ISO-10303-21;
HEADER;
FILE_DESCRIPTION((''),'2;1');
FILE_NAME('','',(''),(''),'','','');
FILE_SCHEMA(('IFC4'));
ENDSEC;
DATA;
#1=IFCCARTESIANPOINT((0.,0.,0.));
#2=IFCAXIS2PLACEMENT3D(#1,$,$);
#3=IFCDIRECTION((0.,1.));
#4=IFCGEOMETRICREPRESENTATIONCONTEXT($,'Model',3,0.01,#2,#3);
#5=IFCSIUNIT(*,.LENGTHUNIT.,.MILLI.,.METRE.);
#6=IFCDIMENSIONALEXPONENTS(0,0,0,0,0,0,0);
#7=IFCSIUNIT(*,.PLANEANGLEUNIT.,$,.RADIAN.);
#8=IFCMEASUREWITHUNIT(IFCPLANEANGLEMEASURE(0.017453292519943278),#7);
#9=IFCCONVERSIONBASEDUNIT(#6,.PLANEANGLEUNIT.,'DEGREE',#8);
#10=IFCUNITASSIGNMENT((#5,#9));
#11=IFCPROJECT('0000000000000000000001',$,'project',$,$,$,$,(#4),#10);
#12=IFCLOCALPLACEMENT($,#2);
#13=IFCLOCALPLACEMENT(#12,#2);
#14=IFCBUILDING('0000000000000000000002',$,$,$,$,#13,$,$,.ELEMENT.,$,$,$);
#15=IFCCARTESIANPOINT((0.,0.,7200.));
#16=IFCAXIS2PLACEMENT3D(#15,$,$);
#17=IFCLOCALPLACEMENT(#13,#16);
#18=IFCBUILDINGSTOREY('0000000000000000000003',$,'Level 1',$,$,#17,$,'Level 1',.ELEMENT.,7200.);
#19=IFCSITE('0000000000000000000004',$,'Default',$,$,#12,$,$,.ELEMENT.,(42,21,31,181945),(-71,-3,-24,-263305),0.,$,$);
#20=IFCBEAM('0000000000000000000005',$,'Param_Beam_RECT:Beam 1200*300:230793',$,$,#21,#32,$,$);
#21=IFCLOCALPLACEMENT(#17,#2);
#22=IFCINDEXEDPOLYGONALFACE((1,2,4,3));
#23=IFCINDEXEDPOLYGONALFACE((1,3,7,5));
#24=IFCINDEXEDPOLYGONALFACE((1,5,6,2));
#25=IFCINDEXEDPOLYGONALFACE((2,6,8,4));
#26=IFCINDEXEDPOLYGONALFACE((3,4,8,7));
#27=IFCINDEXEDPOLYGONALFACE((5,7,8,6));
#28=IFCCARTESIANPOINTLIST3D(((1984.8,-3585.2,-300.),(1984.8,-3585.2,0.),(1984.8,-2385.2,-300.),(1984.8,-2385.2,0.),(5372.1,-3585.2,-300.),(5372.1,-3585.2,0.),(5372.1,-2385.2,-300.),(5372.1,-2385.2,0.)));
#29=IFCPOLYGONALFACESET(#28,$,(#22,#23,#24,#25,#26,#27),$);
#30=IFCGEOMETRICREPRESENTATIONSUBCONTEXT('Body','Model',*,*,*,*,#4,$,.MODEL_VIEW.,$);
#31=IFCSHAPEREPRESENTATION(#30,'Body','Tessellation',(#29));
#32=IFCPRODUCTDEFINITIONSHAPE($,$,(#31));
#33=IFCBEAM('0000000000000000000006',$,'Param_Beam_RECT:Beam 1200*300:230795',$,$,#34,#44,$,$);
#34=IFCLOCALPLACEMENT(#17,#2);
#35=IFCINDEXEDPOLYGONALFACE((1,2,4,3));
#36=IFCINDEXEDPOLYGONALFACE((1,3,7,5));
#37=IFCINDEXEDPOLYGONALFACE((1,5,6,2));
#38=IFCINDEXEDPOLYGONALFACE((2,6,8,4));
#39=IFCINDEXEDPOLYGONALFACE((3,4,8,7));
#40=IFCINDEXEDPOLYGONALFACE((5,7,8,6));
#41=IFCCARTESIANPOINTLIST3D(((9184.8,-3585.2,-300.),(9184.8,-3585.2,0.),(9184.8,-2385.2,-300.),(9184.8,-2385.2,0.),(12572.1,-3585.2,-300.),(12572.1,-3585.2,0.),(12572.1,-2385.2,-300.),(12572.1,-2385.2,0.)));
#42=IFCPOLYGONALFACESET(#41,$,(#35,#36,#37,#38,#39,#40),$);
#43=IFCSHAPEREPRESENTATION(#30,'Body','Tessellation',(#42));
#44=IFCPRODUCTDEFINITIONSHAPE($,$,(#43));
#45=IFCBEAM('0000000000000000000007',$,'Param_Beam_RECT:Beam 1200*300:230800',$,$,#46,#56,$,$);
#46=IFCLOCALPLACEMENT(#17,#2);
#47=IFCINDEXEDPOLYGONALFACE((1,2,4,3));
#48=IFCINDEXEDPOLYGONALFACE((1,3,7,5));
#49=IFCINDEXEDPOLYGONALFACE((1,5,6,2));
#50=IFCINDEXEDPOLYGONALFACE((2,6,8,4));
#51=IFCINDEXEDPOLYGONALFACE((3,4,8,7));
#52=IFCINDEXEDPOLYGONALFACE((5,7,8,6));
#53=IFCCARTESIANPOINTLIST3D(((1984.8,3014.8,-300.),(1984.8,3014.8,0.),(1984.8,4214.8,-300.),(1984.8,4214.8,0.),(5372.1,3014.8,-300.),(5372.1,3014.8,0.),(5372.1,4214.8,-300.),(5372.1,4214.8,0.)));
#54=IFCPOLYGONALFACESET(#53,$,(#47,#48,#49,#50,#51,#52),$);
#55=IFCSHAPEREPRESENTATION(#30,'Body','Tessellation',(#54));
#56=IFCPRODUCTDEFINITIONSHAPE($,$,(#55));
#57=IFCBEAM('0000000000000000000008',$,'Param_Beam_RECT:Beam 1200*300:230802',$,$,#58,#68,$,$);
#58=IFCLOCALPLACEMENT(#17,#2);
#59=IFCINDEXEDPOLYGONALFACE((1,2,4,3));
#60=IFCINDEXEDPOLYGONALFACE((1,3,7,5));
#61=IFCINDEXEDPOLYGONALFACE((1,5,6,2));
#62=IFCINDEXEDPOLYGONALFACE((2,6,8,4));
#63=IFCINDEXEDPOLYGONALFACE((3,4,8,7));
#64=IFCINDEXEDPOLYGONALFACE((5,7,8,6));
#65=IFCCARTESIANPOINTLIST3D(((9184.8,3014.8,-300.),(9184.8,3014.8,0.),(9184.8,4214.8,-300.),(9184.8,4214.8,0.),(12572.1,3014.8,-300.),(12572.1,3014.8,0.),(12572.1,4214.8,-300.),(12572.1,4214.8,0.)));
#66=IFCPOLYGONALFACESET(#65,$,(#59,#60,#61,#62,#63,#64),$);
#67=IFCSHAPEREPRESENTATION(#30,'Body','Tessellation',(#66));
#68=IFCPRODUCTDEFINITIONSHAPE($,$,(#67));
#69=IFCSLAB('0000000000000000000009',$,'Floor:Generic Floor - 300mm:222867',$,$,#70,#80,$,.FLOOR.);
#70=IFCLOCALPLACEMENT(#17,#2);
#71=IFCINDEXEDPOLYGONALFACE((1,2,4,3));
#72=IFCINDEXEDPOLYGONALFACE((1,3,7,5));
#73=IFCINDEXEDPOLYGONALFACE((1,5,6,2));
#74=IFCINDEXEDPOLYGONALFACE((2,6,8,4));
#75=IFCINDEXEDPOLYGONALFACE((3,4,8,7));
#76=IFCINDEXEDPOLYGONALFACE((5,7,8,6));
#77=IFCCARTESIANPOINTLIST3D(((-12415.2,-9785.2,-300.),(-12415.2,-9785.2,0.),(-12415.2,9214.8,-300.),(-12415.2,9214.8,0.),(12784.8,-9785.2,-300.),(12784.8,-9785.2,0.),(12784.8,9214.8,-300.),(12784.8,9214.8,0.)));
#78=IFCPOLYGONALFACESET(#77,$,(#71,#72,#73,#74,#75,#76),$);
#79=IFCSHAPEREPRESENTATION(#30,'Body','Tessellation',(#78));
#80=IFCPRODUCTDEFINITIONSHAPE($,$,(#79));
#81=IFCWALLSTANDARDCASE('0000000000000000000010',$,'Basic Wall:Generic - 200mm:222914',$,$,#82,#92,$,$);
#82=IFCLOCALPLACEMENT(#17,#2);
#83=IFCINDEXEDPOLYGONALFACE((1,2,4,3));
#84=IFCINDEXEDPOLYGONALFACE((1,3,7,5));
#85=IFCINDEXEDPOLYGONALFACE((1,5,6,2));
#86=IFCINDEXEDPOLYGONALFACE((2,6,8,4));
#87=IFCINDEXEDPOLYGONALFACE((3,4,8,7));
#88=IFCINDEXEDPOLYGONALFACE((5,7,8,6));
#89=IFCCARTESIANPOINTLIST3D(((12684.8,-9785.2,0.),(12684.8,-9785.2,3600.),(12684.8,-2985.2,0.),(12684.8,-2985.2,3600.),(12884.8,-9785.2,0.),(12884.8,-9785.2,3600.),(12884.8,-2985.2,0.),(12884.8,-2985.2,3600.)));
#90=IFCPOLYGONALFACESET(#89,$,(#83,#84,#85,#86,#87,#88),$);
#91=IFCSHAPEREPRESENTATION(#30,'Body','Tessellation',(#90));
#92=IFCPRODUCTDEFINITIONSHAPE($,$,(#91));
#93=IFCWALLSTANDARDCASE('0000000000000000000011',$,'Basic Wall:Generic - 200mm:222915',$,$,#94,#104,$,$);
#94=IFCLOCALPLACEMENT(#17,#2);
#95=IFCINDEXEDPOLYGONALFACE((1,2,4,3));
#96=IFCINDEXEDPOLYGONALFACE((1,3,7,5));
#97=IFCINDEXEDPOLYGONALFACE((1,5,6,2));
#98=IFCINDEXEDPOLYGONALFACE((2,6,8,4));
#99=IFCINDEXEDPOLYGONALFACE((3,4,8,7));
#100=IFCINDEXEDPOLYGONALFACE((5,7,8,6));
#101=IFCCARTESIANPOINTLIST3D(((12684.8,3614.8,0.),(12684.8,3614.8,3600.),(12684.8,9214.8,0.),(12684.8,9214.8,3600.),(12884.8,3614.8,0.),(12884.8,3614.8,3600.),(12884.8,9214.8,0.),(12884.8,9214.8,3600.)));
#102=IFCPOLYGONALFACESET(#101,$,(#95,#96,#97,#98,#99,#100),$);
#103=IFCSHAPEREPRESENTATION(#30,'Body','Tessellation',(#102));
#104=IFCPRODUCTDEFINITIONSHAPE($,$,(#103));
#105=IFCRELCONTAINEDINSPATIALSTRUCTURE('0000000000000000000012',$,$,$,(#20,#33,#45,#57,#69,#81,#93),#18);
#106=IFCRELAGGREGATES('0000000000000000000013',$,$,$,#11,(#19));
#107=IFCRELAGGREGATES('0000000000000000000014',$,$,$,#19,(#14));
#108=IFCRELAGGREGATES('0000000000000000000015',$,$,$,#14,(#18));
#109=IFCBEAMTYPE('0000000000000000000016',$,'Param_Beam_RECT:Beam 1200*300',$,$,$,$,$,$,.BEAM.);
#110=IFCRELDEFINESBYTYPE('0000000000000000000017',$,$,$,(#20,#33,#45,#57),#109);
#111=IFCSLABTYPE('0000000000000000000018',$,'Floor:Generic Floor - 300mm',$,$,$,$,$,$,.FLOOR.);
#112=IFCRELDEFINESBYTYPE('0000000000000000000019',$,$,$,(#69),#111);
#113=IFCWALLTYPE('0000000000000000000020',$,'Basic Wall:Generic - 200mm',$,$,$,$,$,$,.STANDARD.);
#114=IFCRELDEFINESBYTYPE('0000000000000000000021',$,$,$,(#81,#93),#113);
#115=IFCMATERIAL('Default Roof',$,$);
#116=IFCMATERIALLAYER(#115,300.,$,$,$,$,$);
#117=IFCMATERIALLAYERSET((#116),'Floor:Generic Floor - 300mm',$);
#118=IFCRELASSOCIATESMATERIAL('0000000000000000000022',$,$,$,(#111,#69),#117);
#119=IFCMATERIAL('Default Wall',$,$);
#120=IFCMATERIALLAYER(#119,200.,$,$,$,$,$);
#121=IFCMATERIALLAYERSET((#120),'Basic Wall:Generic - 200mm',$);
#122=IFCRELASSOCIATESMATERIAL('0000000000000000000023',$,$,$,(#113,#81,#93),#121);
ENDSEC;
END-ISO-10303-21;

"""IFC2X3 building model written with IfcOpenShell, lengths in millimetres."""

from ifc_helpers import new_model, entity, si_unit, converted_unit, direction, frame, frame_2d, origin, origin_2d_with_axis, place, context, subcontext, project, spatial, rectangle, extrude, material, layer, layer_set, layer_usage, type_object, element, save


model = new_model("IFC2X3")

# Units and contexts
model_context = context("Model", 3, precision=0.01, world=origin(), true_north=direction((0.0, 1.0)))
body_context = subcontext(model_context, "Body", "Model", "MODEL_VIEW")
ifc_project = project(units=[si_unit("LENGTHUNIT", "METRE", prefix="MILLI"), converted_unit("PLANEANGLEUNIT", "DEGREE", entity("IfcPlaneAngleMeasure", 0.017453292519943278), si_unit("PLANEANGLEUNIT", "RADIAN"), dimensions=[0, 0, 0, 0, 0, 0, 0])], contexts=[model_context])

# Site, building, storey
site_placement = place(None, origin())
site = spatial("IfcSite", under=ifc_project, at=site_placement, Name="Default", CompositionType="ELEMENT", RefLatitude=(42, 21, 31, 181945), RefLongitude=(-71, -3, -24, -263305), RefElevation=0.0)
building_placement = place(site_placement, origin())
building = spatial("IfcBuilding", under=site, at=building_placement, CompositionType="ELEMENT")
storey_placement = place(building_placement, frame((0.0, 0.0, 7200.0)))
storey = spatial("IfcBuildingStorey", under=building, at=storey_placement, Name="Level 1", LongName="Level 1", CompositionType="ELEMENT", Elevation=7200.0)

# Beams
beam_type_1 = type_object("IfcBeamType", Name="Param_Beam_RECT:Beam 1200*300", PredefinedType="BEAM")
beam_1_placement = place(storey_placement, frame((1984.8, -2985.2, 0.0)))
element("IfcBeam", 1, at=beam_1_placement, inside=storey, type_object=beam_type_1, Name="Param_Beam_RECT:Beam 1200*300:230793", context=body_context, shape_type="SweptSolid", body=[
    extrude(rectangle(XDim=300.0, YDim=1200.0, at=frame_2d((0.0, 0.0), x_axis=(1.0, 0.0))), frame((0.0, 0.0, -150.0), z_axis=(1.0, 0.0, 0.0), x_axis=(0.0, 0.0, -1.0)), (0.0, 0.0, 1.0), 3387.3),
])
beam_2_placement = place(storey_placement, frame((9184.8, -2985.2, 0.0)))
element("IfcBeam", 2, at=beam_2_placement, inside=storey, type_object=beam_type_1, Name="Param_Beam_RECT:Beam 1200*300:230795", context=body_context, shape_type="SweptSolid", body=[
    extrude(rectangle(XDim=300.0, YDim=1200.0, at=frame_2d((0.0, 0.0), x_axis=(1.0, 0.0))), frame((0.0, 0.0, -150.0), z_axis=(1.0, 0.0, 0.0), x_axis=(0.0, 0.0, -1.0)), (0.0, 0.0, 1.0), 3387.3),
])
beam_3_placement = place(storey_placement, frame((1984.8, 3614.8, 0.0)))
element("IfcBeam", 3, at=beam_3_placement, inside=storey, type_object=beam_type_1, Name="Param_Beam_RECT:Beam 1200*300:230800", context=body_context, shape_type="SweptSolid", body=[
    extrude(rectangle(XDim=300.0, YDim=1200.0, at=frame_2d((0.0, 0.0), x_axis=(1.0, 0.0))), frame((0.0, 0.0, -150.0), z_axis=(1.0, 0.0, 0.0), x_axis=(0.0, 0.0, -1.0)), (0.0, 0.0, 1.0), 3387.3),
])
beam_4_placement = place(storey_placement, frame((9184.8, 3614.8, 0.0)))
element("IfcBeam", 4, at=beam_4_placement, inside=storey, type_object=beam_type_1, Name="Param_Beam_RECT:Beam 1200*300:230802", context=body_context, shape_type="SweptSolid", body=[
    extrude(rectangle(XDim=300.0, YDim=1200.0, at=frame_2d((0.0, 0.0), x_axis=(1.0, 0.0))), frame((0.0, 0.0, -150.0), z_axis=(1.0, 0.0, 0.0), x_axis=(0.0, 0.0, -1.0)), (0.0, 0.0, 1.0), 3387.3),
])

# Slab
ifc_material_1 = material(Name="Default Roof")
ifc_layer_1 = layer(ifc_material_1, 300.0)
ifc_layer_set_1 = layer_set([ifc_layer_1], Name="Floor:Generic Floor - 300mm")
ifc_layer_usage_1 = layer_usage(ifc_layer_set_1, "AXIS3", "POSITIVE", 0.0)
slab_type = type_object("IfcSlabType", Name="Floor:Generic Floor - 300mm", PredefinedType="FLOOR", material=ifc_layer_set_1)
slab_placement = place(storey_placement, origin())
element("IfcSlab", 5, at=slab_placement, inside=storey, type_object=slab_type, material=ifc_layer_usage_1, Name="Floor:Generic Floor - 300mm:222867", PredefinedType="FLOOR", context=body_context, shape_type="SweptSolid", body=[
    extrude(rectangle(XDim=19000.0, YDim=25200.0, at=origin_2d_with_axis()), frame((184.8, -285.2, 0.0), z_axis=(0.0, 0.0, -1.0), x_axis=(0.0, 1.0, 0.0)), (0.0, 0.0, 1.0), 300.0),
])

# Walls
ifc_material_2 = material(Name="Default Wall")
ifc_layer_2 = layer(ifc_material_2, 200.0)
ifc_layer_set_2 = layer_set([ifc_layer_2], Name="Basic Wall:Generic - 200mm")
ifc_layer_usage_2 = layer_usage(ifc_layer_set_2, "AXIS2", "NEGATIVE", 100.0)
wall_type = type_object("IfcWallType", Name="Basic Wall:Generic - 200mm", PredefinedType="STANDARD", material=ifc_layer_set_2)
wall_1_placement = place(storey_placement, frame((12784.8, -9785.2, 0.0), z_axis=(0.0, 0.0, 1.0), x_axis=(0.0, 1.0, 0.0)))
element("IfcWallStandardCase", 6, at=wall_1_placement, inside=storey, type_object=wall_type, material=ifc_layer_usage_2, Name="Basic Wall:Generic - 200mm:222914", context=body_context, shape_type="SweptSolid", body=[
    extrude(rectangle(XDim=6800.0, YDim=200.0, at=frame_2d((3400.0, 0.0), x_axis=(-1.0, 0.0))), origin(), (0.0, 0.0, 1.0), 3600.0),
])
ifc_layer_usage_3 = layer_usage(ifc_layer_set_2, "AXIS2", "NEGATIVE", 100.0)
wall_2_placement = place(storey_placement, frame((12784.8, 3614.8, 0.0), z_axis=(0.0, 0.0, 1.0), x_axis=(0.0, 1.0, 0.0)))
element("IfcWallStandardCase", 7, at=wall_2_placement, inside=storey, type_object=wall_type, material=ifc_layer_usage_3, Name="Basic Wall:Generic - 200mm:222915", context=body_context, shape_type="SweptSolid", body=[
    extrude(rectangle(XDim=5600.0, YDim=200.0, at=frame_2d((2800.0, 0.0), x_axis=(-1.0, 0.0))), origin(), (0.0, 0.0, 1.0), 3600.0),
])

save(model, "model.ifc")
